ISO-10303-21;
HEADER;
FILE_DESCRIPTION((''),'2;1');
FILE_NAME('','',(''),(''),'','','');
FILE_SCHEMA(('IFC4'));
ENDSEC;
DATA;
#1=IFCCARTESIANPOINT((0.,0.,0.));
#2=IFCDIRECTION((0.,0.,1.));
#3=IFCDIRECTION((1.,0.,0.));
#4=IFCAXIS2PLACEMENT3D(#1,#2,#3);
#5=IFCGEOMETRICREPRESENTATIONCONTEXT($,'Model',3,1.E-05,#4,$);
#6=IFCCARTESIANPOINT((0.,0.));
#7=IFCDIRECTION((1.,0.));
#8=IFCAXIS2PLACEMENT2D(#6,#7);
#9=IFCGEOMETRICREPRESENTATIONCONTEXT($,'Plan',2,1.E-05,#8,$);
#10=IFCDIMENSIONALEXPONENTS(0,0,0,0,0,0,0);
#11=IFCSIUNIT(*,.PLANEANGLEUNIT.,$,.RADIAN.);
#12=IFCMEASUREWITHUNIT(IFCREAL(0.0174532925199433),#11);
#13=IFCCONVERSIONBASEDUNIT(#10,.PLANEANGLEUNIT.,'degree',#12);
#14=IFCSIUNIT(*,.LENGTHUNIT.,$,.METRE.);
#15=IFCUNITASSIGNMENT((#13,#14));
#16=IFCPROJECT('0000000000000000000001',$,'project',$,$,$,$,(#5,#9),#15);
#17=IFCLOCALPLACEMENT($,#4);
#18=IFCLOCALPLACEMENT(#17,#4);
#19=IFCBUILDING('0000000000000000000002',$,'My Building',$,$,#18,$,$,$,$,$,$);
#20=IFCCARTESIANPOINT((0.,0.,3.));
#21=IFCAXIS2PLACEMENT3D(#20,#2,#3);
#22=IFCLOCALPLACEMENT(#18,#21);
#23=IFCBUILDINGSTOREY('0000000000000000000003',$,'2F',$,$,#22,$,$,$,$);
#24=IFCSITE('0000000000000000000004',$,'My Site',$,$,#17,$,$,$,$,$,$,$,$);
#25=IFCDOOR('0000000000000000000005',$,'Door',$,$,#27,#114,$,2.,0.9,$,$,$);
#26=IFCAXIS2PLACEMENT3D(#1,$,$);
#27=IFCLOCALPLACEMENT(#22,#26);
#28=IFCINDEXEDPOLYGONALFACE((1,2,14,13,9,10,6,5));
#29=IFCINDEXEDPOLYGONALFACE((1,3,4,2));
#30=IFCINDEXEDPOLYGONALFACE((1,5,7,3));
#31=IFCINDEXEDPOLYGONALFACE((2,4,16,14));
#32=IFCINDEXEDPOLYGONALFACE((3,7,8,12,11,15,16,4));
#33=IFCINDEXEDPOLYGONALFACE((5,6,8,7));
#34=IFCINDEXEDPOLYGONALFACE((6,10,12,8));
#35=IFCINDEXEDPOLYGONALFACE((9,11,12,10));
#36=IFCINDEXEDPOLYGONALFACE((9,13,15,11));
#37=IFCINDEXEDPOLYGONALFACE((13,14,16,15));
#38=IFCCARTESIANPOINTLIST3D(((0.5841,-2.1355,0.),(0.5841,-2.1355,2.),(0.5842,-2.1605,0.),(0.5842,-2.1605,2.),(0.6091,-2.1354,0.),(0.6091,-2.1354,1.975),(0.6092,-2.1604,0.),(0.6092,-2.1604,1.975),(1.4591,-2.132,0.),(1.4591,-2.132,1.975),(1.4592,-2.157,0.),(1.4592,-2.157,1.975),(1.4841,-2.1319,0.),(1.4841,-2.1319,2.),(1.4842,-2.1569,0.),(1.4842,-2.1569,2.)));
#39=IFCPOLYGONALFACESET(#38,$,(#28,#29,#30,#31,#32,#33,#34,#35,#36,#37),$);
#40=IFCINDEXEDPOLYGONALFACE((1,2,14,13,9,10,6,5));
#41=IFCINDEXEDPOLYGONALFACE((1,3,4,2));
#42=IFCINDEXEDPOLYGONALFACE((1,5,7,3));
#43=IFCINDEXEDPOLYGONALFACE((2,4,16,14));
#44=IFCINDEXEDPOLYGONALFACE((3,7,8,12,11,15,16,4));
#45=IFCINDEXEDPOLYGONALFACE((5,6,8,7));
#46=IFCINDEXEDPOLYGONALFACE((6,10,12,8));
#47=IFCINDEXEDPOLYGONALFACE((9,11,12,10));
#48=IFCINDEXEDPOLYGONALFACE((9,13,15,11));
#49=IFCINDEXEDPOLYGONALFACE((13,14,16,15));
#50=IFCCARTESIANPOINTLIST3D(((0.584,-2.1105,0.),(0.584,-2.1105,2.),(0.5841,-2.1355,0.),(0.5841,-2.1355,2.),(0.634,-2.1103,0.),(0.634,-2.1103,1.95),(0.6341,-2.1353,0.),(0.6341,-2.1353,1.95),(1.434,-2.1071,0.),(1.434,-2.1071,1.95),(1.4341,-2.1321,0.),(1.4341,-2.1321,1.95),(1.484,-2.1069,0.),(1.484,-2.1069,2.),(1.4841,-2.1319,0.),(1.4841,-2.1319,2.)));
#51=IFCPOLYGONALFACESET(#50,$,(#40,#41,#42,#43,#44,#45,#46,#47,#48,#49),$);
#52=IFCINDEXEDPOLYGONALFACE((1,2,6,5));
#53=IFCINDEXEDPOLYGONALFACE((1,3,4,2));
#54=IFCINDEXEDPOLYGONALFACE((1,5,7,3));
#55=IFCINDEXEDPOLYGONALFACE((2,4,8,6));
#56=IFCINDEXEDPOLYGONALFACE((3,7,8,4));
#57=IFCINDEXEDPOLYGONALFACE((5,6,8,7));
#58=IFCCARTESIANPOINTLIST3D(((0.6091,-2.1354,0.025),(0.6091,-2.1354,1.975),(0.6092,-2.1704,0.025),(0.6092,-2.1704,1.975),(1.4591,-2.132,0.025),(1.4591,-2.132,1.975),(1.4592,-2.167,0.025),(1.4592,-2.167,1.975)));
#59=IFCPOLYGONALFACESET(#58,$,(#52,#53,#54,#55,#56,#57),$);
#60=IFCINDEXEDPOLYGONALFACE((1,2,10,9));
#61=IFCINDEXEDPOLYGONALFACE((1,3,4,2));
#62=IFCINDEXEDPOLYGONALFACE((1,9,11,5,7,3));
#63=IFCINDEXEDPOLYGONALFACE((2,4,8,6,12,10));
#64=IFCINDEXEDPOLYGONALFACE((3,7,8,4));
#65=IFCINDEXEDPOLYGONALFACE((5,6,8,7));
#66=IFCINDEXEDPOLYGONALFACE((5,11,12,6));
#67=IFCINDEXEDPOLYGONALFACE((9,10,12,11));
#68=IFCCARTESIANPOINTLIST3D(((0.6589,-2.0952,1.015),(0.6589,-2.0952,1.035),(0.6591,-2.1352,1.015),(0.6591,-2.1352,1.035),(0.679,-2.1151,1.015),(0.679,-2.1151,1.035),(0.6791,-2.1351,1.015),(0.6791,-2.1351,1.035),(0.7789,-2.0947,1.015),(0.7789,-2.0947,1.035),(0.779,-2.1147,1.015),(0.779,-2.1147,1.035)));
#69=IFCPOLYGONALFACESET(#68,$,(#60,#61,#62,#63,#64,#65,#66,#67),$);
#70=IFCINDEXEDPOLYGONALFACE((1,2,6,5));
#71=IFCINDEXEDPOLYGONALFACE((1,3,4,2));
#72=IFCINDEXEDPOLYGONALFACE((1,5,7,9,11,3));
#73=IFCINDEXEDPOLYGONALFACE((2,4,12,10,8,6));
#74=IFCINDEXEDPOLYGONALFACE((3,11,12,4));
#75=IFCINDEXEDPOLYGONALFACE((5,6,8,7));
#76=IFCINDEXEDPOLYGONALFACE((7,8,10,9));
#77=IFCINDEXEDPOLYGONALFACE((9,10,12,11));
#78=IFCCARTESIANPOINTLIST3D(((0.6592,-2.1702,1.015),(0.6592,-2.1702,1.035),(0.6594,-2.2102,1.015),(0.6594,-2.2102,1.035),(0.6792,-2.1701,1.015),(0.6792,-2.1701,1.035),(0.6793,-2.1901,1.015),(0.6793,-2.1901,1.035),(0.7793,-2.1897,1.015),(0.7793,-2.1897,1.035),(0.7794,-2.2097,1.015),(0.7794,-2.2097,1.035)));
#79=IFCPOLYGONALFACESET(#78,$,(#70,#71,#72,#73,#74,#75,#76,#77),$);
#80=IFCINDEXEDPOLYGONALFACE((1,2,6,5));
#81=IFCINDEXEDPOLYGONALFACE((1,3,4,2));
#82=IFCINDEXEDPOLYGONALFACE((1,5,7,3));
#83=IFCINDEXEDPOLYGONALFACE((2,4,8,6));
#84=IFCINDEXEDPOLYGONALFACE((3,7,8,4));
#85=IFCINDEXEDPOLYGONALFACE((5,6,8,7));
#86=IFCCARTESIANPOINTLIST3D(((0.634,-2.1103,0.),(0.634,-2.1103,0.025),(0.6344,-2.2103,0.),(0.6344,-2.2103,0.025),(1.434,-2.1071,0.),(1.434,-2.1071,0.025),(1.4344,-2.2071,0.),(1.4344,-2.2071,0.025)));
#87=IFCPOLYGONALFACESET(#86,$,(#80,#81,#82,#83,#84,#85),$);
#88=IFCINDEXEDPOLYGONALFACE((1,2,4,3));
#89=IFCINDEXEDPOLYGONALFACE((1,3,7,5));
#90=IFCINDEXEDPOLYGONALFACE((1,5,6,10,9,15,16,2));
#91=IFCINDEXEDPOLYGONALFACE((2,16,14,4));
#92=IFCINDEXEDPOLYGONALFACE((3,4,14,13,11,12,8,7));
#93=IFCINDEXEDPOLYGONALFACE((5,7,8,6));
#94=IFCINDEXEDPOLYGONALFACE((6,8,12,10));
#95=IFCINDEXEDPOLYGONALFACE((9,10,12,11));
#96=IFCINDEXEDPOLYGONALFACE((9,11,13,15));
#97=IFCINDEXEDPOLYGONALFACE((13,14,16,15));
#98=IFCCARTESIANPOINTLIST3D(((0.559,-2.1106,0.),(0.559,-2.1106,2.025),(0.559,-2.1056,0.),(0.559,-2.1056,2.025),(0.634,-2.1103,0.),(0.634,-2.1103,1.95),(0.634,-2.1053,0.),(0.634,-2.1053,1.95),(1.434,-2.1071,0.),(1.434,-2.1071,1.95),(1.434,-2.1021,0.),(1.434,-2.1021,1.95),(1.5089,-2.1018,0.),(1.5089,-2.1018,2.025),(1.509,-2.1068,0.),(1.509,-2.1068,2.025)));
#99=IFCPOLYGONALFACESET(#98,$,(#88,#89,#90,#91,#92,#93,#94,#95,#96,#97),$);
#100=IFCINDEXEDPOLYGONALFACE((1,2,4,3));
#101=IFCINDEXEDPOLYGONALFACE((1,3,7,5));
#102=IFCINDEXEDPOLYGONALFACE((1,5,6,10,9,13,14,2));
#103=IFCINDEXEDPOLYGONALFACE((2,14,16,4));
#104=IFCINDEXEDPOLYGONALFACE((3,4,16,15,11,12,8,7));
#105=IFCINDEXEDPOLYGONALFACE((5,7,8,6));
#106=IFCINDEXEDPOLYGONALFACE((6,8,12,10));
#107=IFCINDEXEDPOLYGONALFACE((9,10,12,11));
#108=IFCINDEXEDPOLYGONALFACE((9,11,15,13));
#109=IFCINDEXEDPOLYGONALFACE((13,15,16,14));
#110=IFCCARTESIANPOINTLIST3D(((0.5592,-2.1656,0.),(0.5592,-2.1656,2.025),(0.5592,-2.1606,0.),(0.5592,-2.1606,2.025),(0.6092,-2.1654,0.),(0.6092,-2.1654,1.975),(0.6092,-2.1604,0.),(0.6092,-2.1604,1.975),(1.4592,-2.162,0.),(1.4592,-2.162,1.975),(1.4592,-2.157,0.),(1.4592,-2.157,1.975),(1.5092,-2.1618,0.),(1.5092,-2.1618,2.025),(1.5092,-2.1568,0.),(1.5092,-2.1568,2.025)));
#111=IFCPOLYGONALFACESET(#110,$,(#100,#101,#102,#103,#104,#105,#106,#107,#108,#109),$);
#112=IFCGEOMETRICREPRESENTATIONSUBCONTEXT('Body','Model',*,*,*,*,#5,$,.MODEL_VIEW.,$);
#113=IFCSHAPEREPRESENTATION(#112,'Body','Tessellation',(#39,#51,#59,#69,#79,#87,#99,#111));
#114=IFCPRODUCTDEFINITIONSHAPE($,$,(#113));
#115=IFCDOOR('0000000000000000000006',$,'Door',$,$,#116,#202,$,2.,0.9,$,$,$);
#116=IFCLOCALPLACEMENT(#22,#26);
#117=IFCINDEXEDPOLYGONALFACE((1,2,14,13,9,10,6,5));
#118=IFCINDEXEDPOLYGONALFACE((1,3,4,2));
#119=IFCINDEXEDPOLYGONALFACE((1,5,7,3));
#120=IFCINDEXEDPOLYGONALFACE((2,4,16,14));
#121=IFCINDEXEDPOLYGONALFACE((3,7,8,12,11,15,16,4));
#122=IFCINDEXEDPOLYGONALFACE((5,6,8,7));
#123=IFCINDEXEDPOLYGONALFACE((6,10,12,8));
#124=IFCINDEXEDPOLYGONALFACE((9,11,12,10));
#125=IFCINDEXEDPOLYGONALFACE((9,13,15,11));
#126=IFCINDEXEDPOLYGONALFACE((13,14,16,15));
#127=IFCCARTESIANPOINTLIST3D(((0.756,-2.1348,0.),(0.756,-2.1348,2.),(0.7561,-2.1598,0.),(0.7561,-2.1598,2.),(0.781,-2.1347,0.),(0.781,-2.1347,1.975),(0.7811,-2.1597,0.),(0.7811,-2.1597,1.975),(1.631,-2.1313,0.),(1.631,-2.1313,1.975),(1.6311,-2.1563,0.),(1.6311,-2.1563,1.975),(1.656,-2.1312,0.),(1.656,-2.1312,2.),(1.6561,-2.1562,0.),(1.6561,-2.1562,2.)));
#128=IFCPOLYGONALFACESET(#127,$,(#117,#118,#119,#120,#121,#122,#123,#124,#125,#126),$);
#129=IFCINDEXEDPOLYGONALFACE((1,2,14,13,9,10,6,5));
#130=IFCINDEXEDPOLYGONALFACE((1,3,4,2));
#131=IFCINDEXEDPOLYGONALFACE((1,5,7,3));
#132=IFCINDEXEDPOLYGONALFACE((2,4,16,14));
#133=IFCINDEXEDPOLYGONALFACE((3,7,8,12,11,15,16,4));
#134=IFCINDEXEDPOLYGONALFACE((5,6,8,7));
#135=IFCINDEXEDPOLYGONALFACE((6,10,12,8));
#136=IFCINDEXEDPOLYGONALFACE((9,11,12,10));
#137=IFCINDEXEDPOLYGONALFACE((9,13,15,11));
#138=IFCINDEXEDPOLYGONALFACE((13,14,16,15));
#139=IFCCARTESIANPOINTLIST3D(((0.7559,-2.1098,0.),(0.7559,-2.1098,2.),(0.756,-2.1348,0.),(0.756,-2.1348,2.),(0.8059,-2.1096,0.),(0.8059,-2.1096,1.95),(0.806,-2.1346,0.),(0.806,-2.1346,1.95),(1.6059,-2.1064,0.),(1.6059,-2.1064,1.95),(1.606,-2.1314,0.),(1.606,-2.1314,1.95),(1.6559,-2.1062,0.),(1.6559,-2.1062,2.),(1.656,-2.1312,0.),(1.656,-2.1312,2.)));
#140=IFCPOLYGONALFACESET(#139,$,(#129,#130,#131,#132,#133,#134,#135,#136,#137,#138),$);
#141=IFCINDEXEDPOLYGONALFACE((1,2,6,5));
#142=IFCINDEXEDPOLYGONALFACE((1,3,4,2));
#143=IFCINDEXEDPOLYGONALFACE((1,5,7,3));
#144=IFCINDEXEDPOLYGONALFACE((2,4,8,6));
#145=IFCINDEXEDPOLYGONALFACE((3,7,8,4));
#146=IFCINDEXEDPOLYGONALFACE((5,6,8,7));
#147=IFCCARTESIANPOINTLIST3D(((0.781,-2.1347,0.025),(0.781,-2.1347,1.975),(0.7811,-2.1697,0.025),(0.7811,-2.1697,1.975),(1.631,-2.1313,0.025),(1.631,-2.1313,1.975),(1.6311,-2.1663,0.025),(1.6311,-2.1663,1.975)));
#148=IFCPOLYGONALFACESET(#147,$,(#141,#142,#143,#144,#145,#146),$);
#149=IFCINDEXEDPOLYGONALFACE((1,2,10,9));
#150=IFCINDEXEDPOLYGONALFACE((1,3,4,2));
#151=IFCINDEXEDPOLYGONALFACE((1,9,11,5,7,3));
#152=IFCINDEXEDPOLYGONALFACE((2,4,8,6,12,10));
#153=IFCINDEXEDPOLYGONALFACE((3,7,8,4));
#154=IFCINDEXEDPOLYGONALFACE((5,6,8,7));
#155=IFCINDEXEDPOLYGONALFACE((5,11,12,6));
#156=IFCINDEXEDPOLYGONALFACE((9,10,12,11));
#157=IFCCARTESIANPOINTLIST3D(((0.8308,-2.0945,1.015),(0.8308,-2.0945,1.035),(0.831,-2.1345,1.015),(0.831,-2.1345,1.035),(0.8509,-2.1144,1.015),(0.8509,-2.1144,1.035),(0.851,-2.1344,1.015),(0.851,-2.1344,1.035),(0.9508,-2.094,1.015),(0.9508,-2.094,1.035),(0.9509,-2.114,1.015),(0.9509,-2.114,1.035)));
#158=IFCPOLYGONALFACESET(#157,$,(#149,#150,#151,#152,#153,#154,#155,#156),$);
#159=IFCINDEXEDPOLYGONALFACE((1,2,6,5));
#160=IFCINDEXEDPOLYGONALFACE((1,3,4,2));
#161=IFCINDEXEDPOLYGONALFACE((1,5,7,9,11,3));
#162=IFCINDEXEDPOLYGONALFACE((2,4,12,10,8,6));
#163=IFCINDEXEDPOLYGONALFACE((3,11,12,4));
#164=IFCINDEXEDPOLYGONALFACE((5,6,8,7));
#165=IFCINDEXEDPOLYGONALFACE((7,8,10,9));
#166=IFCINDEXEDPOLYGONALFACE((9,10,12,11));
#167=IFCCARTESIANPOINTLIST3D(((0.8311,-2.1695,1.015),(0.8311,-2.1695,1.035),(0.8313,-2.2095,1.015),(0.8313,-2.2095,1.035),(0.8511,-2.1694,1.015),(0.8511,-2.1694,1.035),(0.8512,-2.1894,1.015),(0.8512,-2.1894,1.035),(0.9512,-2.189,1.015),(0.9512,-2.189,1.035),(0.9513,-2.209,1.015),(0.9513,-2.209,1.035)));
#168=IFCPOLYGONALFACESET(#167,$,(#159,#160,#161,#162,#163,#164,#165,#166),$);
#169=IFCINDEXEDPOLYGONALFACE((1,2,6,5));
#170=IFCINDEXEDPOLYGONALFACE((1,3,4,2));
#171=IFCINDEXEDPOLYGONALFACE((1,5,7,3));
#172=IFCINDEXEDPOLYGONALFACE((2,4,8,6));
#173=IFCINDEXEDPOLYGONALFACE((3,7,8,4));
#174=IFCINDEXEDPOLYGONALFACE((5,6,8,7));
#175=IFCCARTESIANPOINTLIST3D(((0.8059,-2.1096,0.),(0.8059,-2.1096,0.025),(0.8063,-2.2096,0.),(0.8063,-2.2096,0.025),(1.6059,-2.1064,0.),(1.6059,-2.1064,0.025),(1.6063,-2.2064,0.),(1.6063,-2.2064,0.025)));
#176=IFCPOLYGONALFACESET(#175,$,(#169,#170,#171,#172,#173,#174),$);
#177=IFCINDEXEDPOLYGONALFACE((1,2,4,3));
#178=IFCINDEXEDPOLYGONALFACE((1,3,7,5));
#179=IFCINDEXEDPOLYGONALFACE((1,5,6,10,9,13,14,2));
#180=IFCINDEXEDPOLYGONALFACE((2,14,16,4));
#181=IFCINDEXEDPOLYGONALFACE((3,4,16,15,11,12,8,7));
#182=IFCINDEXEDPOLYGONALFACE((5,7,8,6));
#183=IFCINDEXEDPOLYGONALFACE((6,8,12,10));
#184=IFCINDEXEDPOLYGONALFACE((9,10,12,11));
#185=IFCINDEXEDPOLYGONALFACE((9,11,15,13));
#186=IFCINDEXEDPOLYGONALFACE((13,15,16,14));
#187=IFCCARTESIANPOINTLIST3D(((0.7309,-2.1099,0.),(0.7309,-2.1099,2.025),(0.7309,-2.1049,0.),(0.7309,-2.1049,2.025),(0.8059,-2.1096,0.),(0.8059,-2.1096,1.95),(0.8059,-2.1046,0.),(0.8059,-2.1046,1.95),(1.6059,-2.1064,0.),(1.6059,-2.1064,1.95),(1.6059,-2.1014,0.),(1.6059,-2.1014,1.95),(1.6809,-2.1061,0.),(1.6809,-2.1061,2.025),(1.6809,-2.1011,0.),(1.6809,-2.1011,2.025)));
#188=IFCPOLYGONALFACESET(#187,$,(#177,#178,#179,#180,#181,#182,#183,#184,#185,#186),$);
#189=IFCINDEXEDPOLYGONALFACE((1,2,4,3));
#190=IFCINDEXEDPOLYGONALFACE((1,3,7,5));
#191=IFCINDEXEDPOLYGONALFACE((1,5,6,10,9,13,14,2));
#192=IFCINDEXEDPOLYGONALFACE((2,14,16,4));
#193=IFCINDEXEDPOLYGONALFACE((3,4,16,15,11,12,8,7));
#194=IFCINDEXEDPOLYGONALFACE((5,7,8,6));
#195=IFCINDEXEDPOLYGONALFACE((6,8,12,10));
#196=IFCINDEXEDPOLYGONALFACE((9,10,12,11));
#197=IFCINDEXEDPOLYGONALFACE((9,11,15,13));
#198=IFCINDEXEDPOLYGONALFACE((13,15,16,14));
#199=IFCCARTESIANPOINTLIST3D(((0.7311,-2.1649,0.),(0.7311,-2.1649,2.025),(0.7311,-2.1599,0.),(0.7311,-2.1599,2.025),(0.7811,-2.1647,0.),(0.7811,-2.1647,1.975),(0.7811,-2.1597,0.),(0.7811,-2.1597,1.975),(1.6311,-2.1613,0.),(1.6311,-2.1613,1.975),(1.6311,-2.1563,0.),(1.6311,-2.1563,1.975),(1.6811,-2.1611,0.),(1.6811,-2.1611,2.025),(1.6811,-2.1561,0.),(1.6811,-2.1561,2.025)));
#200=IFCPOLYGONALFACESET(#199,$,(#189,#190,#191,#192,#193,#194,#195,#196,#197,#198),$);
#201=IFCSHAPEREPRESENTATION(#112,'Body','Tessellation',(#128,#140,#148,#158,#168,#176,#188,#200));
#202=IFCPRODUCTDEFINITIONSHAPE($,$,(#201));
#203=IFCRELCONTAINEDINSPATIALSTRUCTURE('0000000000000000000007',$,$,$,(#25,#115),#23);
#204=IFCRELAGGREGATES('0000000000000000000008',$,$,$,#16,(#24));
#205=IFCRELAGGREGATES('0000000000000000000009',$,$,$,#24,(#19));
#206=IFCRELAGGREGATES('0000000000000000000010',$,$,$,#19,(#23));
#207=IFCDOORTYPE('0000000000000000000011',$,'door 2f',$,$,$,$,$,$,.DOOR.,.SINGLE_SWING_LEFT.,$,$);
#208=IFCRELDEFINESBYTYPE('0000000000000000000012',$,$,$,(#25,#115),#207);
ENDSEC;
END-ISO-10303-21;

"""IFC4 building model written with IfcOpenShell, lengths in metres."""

from ifc_helpers import new_model, entity, si_unit, converted_unit, frame, origin_with_axes, origin_2d_with_axis, place, context, subcontext, project, spatial, line, indexed_curve, outline, extrude, shape, source, transform, mapped, type_object, type_shapes, element, save


model = new_model("IFC4")

# Units and contexts
model_context = context("Model", 3, precision=1e-05, world=origin_with_axes())
plan_context = context("Plan", 2, precision=1e-05, world=origin_2d_with_axis())
body_context_1 = subcontext(model_context, "Body", "Model", "MODEL_VIEW")
body_context_2 = subcontext(plan_context, "Body", "Plan", "PLAN_VIEW")
ifc_project = project(units=[converted_unit("PLANEANGLEUNIT", "degree", entity("IfcReal", 0.0174532925199433), si_unit("PLANEANGLEUNIT", "RADIAN"), dimensions=[0, 0, 0, 0, 0, 0, 0]), si_unit("LENGTHUNIT", "METRE")], contexts=[model_context, plan_context])

# Site, building, storey
site_placement = place(None, origin_with_axes())
site = spatial("IfcSite", under=ifc_project, at=site_placement, Name="My Site")
building_placement = place(site_placement, origin_with_axes())
building = spatial("IfcBuilding", under=site, at=building_placement, Name="My Building")
storey_placement = place(building_placement, frame((0.0, 0.0, 3.0), z_axis=(0.0, 0.0, 1.0), x_axis=(1.0, 0.0, 0.0)))
storey = spatial("IfcBuildingStorey", under=building, at=storey_placement, Name="2F")

# Shared definitions
door_type_1 = type_object("IfcDoorType", Name="door 2f", OperationType="SINGLE_SWING_LEFT", PredefinedType="DOOR")
shared_shape_1 = source(origin_with_axes(), body_context_1, "Body", "SweptSolid", [
    extrude(outline(indexed_curve([(0.0, 0.0), (0.0, 2.0), (0.9, 2.0), (0.9, 0.0), (0.875, 0.0), (0.875, 1.975), (0.025, 1.975), (0.025, 0.0)], segments=[line(1, 2, 3, 4, 5, 6, 7, 8, 1)])), frame((0.0, 0.025, 0.0), z_axis=(0.0, -1.0, 0.0), x_axis=(1.0, 0.0, 0.0)), (0.0, 0.0, -1.0), 0.025),
    extrude(outline(indexed_curve([(0.0, 0.0), (0.0, 2.0), (0.9, 2.0), (0.9, 0.0), (0.85, 0.0), (0.85, 1.95), (0.05, 1.95), (0.05, 0.0)], segments=[line(1, 2, 3, 4, 5, 6, 7, 8, 1)])), frame((0.0, 0.0, 0.0), z_axis=(0.0, -1.0, 0.0), x_axis=(1.0, 0.0, 0.0)), (0.0, 0.0, -1.0), 0.025),
    extrude(outline(indexed_curve([(0.0, 0.0), (0.85, 0.0), (0.85, 0.035), (0.0, 0.035)], segments=[line(1, 2, 3, 4, 1)])), frame((0.025, 0.025, 0.025), z_axis=(0.0, 0.0, 1.0), x_axis=(1.0, 0.0, 0.0)), (0.0, 0.0, 1.0), 1.95),
    extrude(outline(indexed_curve([(0.0, 0.0), (0.0, -0.04), (-0.12, -0.04), (-0.12, -0.02), (-0.02, -0.02), (-0.02, 0.0)], segments=[line(1, 2, 3, 4, 5, 6, 1)])), frame((0.825, 0.025, 1.015), z_axis=(0.0, 0.0, 1.0), x_axis=(1.0, 0.0, 0.0)), (0.0, 0.0, 1.0), 0.02),
    extrude(outline(indexed_curve([(0.0, 0.0), (0.0, 0.04), (-0.12, 0.04), (-0.12, 0.02), (-0.02, 0.02), (-0.02, 0.0)], segments=[line(1, 2, 3, 4, 5, 6, 1)])), frame((0.825, 0.06, 1.015), z_axis=(0.0, 0.0, 1.0), x_axis=(1.0, 0.0, 0.0)), (0.0, 0.0, 1.0), 0.02),
    extrude(outline(indexed_curve([(0.0, 0.0), (0.8, 0.0), (0.8, 0.1), (0.0, 0.1)], segments=[line(1, 2, 3, 4, 1)])), frame((0.05, 0.0, 0.0), z_axis=(0.0, 0.0, 1.0), x_axis=(1.0, 0.0, 0.0)), (0.0, 0.0, 1.0), 0.025),
    extrude(outline(indexed_curve([(0.0, 0.0), (0.0, 2.025), (0.95, 2.025), (0.95, 0.0), (0.875, 0.0), (0.875, 1.95), (0.075, 1.95), (0.075, 0.0)], segments=[line(1, 2, 3, 4, 5, 6, 7, 8, 1)])), frame((-0.025, -0.005, 0.0), z_axis=(0.0, -1.0, 0.0), x_axis=(1.0, 0.0, 0.0)), (0.0, 0.0, -1.0), 0.005),
    extrude(outline(indexed_curve([(0.0, 0.0), (0.0, 2.025), (0.95, 2.025), (0.95, 0.0), (0.9, 0.0), (0.9, 1.975), (0.05, 1.975), (0.05, 0.0)], segments=[line(1, 2, 3, 4, 5, 6, 7, 8, 1)])), frame((-0.025, 0.05, 0.0), z_axis=(0.0, -1.0, 0.0), x_axis=(1.0, 0.0, 0.0)), (0.0, 0.0, -1.0), 0.005),
])
shared_shape_2 = source(origin_with_axes(), body_context_2, "Body", "Curve2D", [
    entity("IfcIndexedPolyCurve", entity("IfcCartesianPointList2D", [[0.0, 0.0], [0.0, 0.05], [0.025, 0.05], [0.025, 0.025], [0.05, 0.025], [0.05, 0.0]]), [entity("IfcLineIndex", [1, 2, 3, 4, 5, 6, 1])]),
    entity("IfcIndexedPolyCurve", entity("IfcCartesianPointList2D", [[0.9, 0.0], [0.9, 0.05], [0.875, 0.05], [0.875, 0.025], [0.85, 0.025], [0.85, 0.0]]), [entity("IfcLineIndex", [1, 2, 3, 4, 5, 6, 1])]),
    entity("IfcTrimmedCurve", entity("IfcEllipse", entity("IfcAxis2Placement2D", entity("IfcCartesianPoint", [0.06, 0.05]), entity("IfcDirection", [1.0, 0.0])), 0.815, 0.85), [entity("IfcCartesianPoint", [0.875, 0.05])], [entity("IfcCartesianPoint", [0.06, 0.9])], True, "CARTESIAN"),
    entity("IfcIndexedPolyCurve", entity("IfcCartesianPointList2D", [[0.025, 0.05], [0.06, 0.05], [0.06, 0.9], [0.025, 0.9]]), [entity("IfcLineIndex", [1, 2, 3, 4, 1])]),
])
type_shapes(door_type_1, [shared_shape_1, shared_shape_2])

# Doors
placement_1 = place(storey_placement, frame((1.9233, -2.1051, 0.0), z_axis=(0.0, 0.0, 1.0), x_axis=(-0.999992, -0.004003, 0.0)))
placement_2 = place(placement_1, frame((0.4393, 0.0, 0.0), z_axis=(0.0, 0.0, 1.0), x_axis=(1.0, 0.0, 0.0)))
door_1_placement = place(placement_2, frame((0.0, 0.0, 0.0), z_axis=(0.0, 0.0, 1.0), x_axis=(1.0, 0.0, 0.0)))
element("IfcDoor", 1, at=door_1_placement, inside=storey, type_object=door_type_1, Name="Door", OverallHeight=2.0, OverallWidth=0.9, shapes=[
    shape(body_context_1, "Body", "MappedRepresentation", [mapped(shared_shape_1, transform((0.0, 0.0, 0.0), x_axis=(1.0, 0.0, 0.0), y_axis=(0.0, 1.0, 0.0), z_axis=(0.0, 0.0, 1.0), scale=1.0))]),
    shape(body_context_2, "Body", "MappedRepresentation", [mapped(shared_shape_2, transform((0.0, 0.0, 0.0), x_axis=(1.0, 0.0, 0.0), y_axis=(0.0, 1.0, 0.0), z_axis=(0.0, 0.0, 1.0), scale=1.0))]),
])
placement_3 = place(placement_1, frame((0.2674, 0.0, 0.0), z_axis=(0.0, 0.0, 1.0), x_axis=(1.0, 0.0, 0.0)))
door_2_placement = place(placement_3, origin_with_axes())
element("IfcDoor", 2, at=door_2_placement, inside=storey, type_object=door_type_1, Name="Door", OverallHeight=2.0, OverallWidth=0.9, shapes=[
    shape(body_context_1, "Body", "MappedRepresentation", [mapped(shared_shape_1, transform((0.0, 0.0, 0.0), x_axis=(1.0, 0.0, 0.0), y_axis=(0.0, 1.0, 0.0), z_axis=(0.0, 0.0, 1.0), scale=1.0))]),
    shape(body_context_2, "Body", "MappedRepresentation", [mapped(shared_shape_2, transform((0.0, 0.0, 0.0), x_axis=(1.0, 0.0, 0.0), y_axis=(0.0, 1.0, 0.0), z_axis=(0.0, 0.0, 1.0), scale=1.0))]),
])

save(model, "model.ifc")
